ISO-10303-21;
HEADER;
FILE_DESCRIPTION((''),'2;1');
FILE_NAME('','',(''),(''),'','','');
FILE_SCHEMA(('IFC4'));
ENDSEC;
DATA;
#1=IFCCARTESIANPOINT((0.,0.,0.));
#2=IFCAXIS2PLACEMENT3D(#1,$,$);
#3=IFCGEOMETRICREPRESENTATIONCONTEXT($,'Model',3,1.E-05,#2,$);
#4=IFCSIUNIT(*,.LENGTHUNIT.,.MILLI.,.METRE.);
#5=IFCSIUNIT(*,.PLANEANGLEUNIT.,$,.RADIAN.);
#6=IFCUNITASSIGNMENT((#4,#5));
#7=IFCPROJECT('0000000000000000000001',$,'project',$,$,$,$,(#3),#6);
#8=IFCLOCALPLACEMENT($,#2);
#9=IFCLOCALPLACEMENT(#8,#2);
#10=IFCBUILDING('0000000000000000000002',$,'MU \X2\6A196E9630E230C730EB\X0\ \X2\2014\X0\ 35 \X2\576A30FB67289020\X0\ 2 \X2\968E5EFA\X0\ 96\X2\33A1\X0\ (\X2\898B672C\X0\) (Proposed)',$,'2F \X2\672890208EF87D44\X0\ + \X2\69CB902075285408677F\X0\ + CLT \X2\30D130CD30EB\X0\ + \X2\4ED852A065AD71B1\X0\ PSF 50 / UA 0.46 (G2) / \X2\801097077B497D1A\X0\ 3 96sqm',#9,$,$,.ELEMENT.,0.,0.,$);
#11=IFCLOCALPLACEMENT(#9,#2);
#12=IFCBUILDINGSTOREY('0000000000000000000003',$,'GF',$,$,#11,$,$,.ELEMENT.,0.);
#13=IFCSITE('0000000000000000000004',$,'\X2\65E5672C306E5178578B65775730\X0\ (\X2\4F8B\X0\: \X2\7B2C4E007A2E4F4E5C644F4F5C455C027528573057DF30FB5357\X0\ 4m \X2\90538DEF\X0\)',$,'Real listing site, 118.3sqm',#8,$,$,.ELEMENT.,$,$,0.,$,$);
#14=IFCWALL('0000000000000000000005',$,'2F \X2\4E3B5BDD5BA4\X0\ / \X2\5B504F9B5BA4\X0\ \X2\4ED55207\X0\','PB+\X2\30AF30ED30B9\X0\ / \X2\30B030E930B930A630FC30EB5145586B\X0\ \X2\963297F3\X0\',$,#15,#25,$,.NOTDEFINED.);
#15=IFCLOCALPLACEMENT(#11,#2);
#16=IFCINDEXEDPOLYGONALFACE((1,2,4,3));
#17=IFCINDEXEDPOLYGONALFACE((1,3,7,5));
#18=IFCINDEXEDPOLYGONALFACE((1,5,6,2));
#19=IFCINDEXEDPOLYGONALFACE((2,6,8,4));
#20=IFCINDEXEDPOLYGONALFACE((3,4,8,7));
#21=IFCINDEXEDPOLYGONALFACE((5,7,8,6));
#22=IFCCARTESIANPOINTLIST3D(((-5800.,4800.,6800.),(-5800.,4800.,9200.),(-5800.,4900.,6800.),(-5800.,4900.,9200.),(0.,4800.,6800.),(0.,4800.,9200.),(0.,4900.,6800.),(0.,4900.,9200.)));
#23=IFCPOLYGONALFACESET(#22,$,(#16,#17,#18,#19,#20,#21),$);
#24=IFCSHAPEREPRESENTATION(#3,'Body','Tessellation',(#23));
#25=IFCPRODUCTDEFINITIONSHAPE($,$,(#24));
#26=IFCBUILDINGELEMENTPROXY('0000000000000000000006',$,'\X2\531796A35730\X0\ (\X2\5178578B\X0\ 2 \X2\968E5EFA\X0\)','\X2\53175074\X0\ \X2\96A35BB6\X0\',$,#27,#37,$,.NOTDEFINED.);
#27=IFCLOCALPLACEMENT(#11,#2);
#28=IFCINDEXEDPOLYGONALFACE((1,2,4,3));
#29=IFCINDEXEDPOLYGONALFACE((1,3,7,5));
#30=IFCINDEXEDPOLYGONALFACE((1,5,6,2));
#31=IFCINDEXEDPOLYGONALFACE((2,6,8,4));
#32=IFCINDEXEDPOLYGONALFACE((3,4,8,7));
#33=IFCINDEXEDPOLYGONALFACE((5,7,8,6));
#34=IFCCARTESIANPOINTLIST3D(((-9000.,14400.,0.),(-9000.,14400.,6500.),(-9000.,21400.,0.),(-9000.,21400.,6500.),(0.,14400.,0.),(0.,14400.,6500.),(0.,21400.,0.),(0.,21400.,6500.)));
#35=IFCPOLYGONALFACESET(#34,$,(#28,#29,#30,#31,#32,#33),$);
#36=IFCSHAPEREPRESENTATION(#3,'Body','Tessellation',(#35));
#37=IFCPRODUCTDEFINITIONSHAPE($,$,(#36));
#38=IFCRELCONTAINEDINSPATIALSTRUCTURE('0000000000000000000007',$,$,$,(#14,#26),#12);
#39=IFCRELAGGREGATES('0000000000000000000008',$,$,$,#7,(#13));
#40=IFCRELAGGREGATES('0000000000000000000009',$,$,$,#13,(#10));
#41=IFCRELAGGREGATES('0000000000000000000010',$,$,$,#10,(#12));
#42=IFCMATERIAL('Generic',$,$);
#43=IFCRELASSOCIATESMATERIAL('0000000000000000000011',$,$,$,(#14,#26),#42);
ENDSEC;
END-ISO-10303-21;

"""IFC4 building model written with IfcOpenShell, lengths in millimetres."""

from ifc_helpers import new_model, si_unit, frame, frame_2d, origin, place, context, project, spatial, rectangle, extrude, material, element, save


model = new_model("IFC4")

# Units and contexts
model_context = context("Model", 3, precision=1e-05, world=origin())
ifc_project = project(units=[si_unit("LENGTHUNIT", "METRE", prefix="MILLI"), si_unit("PLANEANGLEUNIT", "RADIAN")], contexts=[model_context])

# Site, building, storey
site_placement = place(None, origin())
site = spatial("IfcSite", under=ifc_project, at=site_placement, Name="日本の典型敷地 (例: 第一種低層住居専用地域・南 4m 道路)", ObjectType="Real listing site, 118.3sqm", CompositionType="ELEMENT", RefElevation=0.0)
building_placement = place(site_placement, origin())
building = spatial("IfcBuilding", under=site, at=building_placement, Name="MU 標準モデル — 35 坪・木造 2 階建 96㎡ (見本) (Proposed)", ObjectType="2F 木造軸組 + 構造用合板 + CLT パネル + 付加断熱 PSF 50 / UA 0.46 (G2) / 耐震等級 3 96sqm", CompositionType="ELEMENT", ElevationOfRefHeight=0.0, ElevationOfTerrain=0.0)
storey_placement = place(building_placement, origin())
storey = spatial("IfcBuildingStorey", under=building, at=storey_placement, Name="GF", CompositionType="ELEMENT", Elevation=0.0)

# Shared definitions
ifc_material_1 = material(Name="Generic")

# Wall
wall_1_placement = place(storey_placement, frame((-2900.0, 2400.0, 3400.0)))
element("IfcWall", 1, at=wall_1_placement, inside=storey, material=ifc_material_1, Name="2F 主寝室 / 子供室 仕切", Description="PB+クロス / グラスウール充填 防音", PredefinedType="NOTDEFINED", context=model_context, shape_type="SweptSolid", body=[
    extrude(rectangle(XDim=5800.0, YDim=100.0, at=frame_2d((2900.0, 50.0))), frame((-2900.0, 2400.0, 3400.0)), (0.0, 0.0, 1.0), 2400.0),
])

# Building element proxy
proxy_1_placement = place(storey_placement, frame((-4500.0, 7200.0, 0.0)))
element("IfcBuildingElementProxy", 2, at=proxy_1_placement, inside=storey, material=ifc_material_1, Name="北隣地 (典型 2 階建)", Description="北側 隣家", PredefinedType="NOTDEFINED", context=model_context, shape_type="SweptSolid", body=[
    extrude(rectangle(XDim=9000.0, YDim=7000.0, at=frame_2d((4500.0, 3500.0))), frame((-4500.0, 7200.0, 0.0)), (0.0, 0.0, 1.0), 6500.0),
])

save(model, "model.ifc")
